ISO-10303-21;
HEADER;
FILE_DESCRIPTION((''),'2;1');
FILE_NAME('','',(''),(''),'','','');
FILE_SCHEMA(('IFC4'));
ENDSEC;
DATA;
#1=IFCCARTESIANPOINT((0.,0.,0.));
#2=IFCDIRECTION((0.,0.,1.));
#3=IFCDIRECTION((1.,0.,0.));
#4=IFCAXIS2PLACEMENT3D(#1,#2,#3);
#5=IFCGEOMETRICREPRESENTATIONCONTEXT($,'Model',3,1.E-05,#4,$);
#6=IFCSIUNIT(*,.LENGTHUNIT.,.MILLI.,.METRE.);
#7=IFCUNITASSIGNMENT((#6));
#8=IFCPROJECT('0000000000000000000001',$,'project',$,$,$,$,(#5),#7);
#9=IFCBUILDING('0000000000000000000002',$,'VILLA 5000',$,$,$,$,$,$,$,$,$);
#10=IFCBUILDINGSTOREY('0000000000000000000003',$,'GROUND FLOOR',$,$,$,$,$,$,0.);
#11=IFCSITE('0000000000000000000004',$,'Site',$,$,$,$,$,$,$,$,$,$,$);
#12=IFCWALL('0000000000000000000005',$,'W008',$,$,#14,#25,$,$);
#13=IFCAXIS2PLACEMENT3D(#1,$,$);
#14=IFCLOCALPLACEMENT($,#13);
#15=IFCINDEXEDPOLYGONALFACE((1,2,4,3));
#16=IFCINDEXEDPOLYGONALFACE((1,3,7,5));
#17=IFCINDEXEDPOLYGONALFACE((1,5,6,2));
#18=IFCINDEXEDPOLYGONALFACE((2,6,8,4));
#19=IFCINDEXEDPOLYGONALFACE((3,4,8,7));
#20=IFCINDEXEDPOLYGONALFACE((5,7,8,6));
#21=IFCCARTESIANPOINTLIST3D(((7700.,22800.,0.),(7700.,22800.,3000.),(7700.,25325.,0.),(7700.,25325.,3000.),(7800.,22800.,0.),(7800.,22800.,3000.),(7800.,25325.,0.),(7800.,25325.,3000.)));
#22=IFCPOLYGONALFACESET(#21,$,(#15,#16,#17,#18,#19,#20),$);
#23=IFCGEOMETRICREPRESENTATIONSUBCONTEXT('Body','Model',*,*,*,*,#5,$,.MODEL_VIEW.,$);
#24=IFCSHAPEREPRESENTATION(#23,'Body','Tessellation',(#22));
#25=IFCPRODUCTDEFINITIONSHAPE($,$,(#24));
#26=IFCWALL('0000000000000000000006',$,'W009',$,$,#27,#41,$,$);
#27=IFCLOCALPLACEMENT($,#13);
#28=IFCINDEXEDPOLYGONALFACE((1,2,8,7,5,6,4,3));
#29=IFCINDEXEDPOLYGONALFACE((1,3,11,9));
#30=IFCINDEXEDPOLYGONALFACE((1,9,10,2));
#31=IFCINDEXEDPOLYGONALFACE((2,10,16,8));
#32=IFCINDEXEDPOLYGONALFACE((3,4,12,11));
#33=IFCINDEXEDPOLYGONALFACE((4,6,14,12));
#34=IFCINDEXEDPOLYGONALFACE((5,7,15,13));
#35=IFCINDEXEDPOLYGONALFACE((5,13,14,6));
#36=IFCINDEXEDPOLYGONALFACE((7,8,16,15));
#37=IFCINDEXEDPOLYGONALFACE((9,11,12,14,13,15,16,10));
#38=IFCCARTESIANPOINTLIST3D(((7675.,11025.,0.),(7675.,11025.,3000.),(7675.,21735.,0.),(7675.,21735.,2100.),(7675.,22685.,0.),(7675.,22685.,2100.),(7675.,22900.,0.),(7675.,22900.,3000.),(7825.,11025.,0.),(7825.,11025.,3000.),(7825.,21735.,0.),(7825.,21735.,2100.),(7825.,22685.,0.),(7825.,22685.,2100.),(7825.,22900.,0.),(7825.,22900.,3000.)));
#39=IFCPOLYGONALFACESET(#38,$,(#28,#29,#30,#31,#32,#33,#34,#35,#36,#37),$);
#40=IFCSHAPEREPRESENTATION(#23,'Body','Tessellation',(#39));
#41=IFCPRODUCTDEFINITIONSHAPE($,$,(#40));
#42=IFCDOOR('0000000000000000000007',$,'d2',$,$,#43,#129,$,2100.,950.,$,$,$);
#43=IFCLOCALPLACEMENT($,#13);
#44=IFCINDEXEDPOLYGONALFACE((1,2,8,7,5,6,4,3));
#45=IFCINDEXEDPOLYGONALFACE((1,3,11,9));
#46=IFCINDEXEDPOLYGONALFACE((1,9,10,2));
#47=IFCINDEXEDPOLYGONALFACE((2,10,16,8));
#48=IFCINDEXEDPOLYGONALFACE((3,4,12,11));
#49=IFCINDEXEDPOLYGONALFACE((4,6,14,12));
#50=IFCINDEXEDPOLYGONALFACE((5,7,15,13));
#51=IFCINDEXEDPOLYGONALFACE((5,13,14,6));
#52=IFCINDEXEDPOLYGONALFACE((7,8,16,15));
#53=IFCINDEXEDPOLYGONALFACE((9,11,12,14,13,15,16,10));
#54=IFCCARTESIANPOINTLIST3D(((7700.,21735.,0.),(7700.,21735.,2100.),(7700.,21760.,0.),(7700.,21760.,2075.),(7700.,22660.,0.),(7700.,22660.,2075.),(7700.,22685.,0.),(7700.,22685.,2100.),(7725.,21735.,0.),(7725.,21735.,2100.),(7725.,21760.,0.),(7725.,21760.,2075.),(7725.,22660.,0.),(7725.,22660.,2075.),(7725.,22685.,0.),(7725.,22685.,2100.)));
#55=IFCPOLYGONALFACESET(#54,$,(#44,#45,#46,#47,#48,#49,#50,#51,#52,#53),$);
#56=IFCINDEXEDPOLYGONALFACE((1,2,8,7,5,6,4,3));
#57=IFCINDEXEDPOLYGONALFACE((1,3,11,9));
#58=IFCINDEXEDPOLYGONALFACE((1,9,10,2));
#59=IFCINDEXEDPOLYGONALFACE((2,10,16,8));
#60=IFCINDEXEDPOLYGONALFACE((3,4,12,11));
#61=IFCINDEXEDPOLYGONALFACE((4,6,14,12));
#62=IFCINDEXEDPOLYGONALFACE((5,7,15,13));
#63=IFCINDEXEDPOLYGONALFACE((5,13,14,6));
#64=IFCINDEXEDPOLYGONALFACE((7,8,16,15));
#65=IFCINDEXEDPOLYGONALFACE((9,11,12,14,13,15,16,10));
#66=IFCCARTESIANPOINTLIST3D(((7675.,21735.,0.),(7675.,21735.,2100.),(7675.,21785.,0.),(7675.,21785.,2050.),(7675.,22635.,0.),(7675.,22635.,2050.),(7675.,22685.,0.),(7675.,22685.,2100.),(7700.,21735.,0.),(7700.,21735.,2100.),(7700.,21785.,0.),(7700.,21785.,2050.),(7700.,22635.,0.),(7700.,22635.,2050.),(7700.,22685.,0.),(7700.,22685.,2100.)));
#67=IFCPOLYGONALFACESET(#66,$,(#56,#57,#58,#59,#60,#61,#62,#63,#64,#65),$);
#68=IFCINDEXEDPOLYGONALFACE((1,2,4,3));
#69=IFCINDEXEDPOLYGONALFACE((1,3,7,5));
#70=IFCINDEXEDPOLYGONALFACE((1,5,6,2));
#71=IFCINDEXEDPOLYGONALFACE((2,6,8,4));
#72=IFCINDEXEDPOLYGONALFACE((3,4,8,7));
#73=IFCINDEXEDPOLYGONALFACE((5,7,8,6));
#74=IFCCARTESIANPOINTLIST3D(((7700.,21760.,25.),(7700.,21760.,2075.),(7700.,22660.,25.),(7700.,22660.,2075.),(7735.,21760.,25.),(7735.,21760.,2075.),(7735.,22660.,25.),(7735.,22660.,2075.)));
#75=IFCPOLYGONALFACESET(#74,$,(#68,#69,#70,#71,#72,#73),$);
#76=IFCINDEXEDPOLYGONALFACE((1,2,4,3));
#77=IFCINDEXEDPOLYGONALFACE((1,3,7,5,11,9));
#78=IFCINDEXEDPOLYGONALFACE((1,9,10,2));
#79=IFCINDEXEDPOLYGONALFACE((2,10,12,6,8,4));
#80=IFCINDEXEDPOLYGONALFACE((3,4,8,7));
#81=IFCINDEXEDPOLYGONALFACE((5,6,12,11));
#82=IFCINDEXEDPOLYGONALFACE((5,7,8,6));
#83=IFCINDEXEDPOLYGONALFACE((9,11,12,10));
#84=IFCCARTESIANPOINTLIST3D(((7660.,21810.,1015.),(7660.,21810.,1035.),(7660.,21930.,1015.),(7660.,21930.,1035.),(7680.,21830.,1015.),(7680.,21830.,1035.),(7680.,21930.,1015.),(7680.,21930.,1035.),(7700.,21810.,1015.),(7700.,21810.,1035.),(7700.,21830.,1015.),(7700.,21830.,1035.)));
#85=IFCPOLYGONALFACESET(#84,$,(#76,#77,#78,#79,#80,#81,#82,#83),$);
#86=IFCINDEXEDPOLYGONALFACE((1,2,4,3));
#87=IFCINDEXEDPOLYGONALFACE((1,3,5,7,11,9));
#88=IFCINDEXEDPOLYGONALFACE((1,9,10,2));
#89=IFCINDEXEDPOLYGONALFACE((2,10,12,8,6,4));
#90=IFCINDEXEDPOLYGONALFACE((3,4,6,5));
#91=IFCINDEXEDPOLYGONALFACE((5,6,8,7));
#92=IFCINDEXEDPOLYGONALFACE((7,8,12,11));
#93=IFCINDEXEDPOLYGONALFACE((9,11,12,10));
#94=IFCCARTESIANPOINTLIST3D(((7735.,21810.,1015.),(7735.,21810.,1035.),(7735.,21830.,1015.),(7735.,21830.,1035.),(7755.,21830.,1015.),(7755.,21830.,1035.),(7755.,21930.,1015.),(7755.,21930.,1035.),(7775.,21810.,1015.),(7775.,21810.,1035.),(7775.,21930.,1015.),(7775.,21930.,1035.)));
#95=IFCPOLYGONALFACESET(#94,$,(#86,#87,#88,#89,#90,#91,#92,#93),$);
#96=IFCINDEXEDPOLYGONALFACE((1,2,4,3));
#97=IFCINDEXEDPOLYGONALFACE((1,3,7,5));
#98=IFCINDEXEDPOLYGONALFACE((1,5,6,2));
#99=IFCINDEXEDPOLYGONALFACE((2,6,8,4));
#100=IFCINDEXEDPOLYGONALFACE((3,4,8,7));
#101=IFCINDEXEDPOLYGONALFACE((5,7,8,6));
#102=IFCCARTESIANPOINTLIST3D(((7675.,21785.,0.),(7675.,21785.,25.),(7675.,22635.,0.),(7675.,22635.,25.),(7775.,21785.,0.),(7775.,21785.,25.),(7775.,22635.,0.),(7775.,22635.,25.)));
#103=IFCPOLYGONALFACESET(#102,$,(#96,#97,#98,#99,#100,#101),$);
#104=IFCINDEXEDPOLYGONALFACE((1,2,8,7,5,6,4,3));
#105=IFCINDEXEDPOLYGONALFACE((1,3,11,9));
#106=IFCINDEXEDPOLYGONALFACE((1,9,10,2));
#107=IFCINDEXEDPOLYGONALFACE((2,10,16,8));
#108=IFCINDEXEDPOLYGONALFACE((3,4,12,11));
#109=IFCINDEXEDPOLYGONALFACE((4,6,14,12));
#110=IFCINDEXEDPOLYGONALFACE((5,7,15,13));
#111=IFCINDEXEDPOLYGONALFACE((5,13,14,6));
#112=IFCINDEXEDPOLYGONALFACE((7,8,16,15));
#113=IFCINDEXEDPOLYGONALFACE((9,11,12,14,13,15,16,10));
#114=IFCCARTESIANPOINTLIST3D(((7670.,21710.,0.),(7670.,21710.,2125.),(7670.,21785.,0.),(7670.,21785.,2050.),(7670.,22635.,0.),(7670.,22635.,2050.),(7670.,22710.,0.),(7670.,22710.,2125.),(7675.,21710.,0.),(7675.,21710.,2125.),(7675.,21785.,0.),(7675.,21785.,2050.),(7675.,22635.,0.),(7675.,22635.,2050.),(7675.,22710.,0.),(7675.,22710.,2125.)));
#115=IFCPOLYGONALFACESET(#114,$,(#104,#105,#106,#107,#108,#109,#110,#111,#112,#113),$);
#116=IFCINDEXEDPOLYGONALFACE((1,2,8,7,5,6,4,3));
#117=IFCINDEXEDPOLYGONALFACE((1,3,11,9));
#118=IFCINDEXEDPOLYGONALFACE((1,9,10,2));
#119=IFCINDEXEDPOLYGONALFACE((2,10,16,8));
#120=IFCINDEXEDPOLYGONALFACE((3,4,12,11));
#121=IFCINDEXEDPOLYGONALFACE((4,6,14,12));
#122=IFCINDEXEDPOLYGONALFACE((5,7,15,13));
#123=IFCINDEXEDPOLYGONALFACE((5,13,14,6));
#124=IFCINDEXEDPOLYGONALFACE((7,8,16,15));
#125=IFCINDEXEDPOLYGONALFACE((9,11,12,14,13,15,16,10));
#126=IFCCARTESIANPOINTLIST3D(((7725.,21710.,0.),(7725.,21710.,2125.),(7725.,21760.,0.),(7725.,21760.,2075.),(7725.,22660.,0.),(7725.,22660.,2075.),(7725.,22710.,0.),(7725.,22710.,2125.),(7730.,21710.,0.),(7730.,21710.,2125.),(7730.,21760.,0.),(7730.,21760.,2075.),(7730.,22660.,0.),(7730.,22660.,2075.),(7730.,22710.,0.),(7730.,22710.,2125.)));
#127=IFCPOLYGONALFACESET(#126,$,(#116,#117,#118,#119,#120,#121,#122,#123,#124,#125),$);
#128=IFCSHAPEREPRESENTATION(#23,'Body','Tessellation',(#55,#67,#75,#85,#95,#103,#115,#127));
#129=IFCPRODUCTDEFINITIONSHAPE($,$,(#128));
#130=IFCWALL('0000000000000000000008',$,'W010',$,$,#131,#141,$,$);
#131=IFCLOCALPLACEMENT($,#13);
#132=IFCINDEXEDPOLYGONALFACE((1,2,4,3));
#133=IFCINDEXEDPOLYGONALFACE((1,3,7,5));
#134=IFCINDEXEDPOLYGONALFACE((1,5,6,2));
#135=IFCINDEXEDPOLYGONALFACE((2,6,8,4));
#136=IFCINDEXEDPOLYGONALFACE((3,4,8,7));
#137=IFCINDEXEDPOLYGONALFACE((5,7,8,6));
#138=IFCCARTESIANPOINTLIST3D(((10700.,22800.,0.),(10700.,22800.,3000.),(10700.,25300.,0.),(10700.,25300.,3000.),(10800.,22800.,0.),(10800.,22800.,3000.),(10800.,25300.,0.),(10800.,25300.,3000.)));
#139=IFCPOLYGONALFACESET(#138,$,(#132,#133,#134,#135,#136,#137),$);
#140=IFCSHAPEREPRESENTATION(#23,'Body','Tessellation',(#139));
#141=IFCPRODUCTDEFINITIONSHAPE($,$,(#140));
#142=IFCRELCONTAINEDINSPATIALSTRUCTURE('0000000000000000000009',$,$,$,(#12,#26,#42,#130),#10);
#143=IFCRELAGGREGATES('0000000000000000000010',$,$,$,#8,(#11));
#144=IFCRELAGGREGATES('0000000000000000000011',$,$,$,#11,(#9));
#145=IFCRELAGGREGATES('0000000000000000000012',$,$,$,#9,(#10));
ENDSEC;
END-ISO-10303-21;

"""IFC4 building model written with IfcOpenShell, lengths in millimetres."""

from ifc_helpers import new_model, si_unit, frame, origin_with_axes, place, context, subcontext, project, spatial, line, indexed_curve, outline, extrude, element, fill, save


model = new_model("IFC4")

# Units and contexts
model_context = context("Model", 3, precision=1e-05, world=origin_with_axes())
body_context = subcontext(model_context, "Body", "Model", "MODEL_VIEW")
ifc_project = project(units=[si_unit("LENGTHUNIT", "METRE", prefix="MILLI")], contexts=[model_context])

# Site, building, storey
site = spatial("IfcSite", under=ifc_project, Name="Site")
building = spatial("IfcBuilding", under=site, Name="VILLA 5000")
storey = spatial("IfcBuildingStorey", under=building, Name="GROUND FLOOR", Elevation=0.0)

# Wall
wall_1_placement = place(None, frame((7750.0, 25325.0, 0.0), z_axis=(0.0, 0.0, 1.0), x_axis=(0.0, -1.0, 0.0)))
element("IfcWall", 1, at=wall_1_placement, inside=storey, Name="W008", context=body_context, shape_type="SweptSolid", body=[
    extrude(outline(indexed_curve([(0.0, 0.0), (0.0, 100.0), (2525.0, 100.0), (2525.0, 0.0), (0.0, 0.0)], self_intersect=False)), frame((0.0, -50.0, 0.0), z_axis=(0.0, 0.0, 1.0), x_axis=(1.0, 0.0, 0.0)), (0.0, 0.0, 1.0), 3000.0),
])

# Wall, opening, door
wall_2_placement = place(None, frame((7750.0, 22900.0, 0.0), z_axis=(0.0, 0.0, 1.0), x_axis=(0.0, -1.0, 0.0)))
wall_2 = element("IfcWall", 2, at=wall_2_placement, inside=storey, Name="W009", context=body_context, shape_type="SweptSolid", body=[
    extrude(outline(indexed_curve([(0.0, 0.0), (0.0, 150.0), (11875.0, 150.0), (11875.0, 0.0), (0.0, 0.0)], self_intersect=False)), frame((0.0, -75.0, 0.0), z_axis=(0.0, 0.0, 1.0), x_axis=(1.0, 0.0, 0.0)), (0.0, 0.0, 1.0), 3000.0),
])
opening_1_placement = place(wall_2_placement, frame((215.0, 0.0, 0.0), z_axis=(0.0, 0.0, 1.0), x_axis=(1.0, 0.0, 0.0)))
opening_1 = element("IfcOpeningElement", 3, at=opening_1_placement, cuts=wall_2, context=body_context, shape_type="SweptSolid", body=[
    extrude(outline(indexed_curve([(0.0, 0.0), (0.0, 250.0), (950.0, 250.0), (950.0, 0.0), (0.0, 0.0)], self_intersect=False)), frame((0.0, -125.0, 0.0), z_axis=(0.0, 0.0, 1.0), x_axis=(1.0, 0.0, 0.0)), (0.0, 0.0, 1.0), 2100.0),
])
door_1_placement = place(None, frame((7675.0, 22685.0, 0.0), z_axis=(0.0, 0.0, 1.0), x_axis=(0.0, -1.0, 0.0)))
door_1 = element("IfcDoor", 4, at=door_1_placement, inside=storey, Name="d2", OverallHeight=2100.0, OverallWidth=950.0, context=body_context, shape_type="SweptSolid", body=[
    extrude(outline(indexed_curve([(0.0, 0.0), (0.0, 2100.0), (950.0, 2100.0), (950.0, 0.0), (925.0, 0.0), (925.0, 2075.0), (25.0, 2075.0), (25.0, 0.0)], segments=[line(1, 2, 3, 4, 5, 6, 7, 8, 1)])), frame((0.0, 25.0, 0.0), z_axis=(0.0, -1.0, 0.0), x_axis=(1.0, 0.0, 0.0)), (0.0, 0.0, -1.0), 25.0),
    extrude(outline(indexed_curve([(0.0, 0.0), (0.0, 2100.0), (950.0, 2100.0), (950.0, 0.0), (900.0, 0.0), (900.0, 2050.0), (50.0, 2050.0), (50.0, 0.0)], segments=[line(1, 2, 3, 4, 5, 6, 7, 8, 1)])), frame((0.0, 0.0, 0.0), z_axis=(0.0, -1.0, 0.0), x_axis=(1.0, 0.0, 0.0)), (0.0, 0.0, -1.0), 25.0),
    extrude(outline(indexed_curve([(0.0, 0.0), (900.0, 0.0), (900.0, 35.0), (0.0, 35.0)], segments=[line(1, 2, 3, 4, 1)])), frame((25.0, 25.0, 25.0), z_axis=(0.0, 0.0, 1.0), x_axis=(1.0, 0.0, 0.0)), (0.0, 0.0, 1.0), 2050.0),
    extrude(outline(indexed_curve([(0.0, 0.0), (0.0, -40.0), (-120.0, -40.0), (-120.0, -20.0), (-20.0, -20.0), (-20.0, 0.0)], segments=[line(1, 2, 3, 4, 5, 6, 1)])), frame((875.0, 25.0, 1015.0), z_axis=(0.0, 0.0, 1.0), x_axis=(1.0, 0.0, 0.0)), (0.0, 0.0, 1.0), 20.0),
    extrude(outline(indexed_curve([(0.0, 0.0), (0.0, 40.0), (-120.0, 40.0), (-120.0, 20.0), (-20.0, 20.0), (-20.0, 0.0)], segments=[line(1, 2, 3, 4, 5, 6, 1)])), frame((875.0, 60.0, 1015.0), z_axis=(0.0, 0.0, 1.0), x_axis=(1.0, 0.0, 0.0)), (0.0, 0.0, 1.0), 20.0),
    extrude(outline(indexed_curve([(0.0, 0.0), (850.0, 0.0), (850.0, 100.0), (0.0, 100.0)], segments=[line(1, 2, 3, 4, 1)])), frame((50.0, 0.0, 0.0), z_axis=(0.0, 0.0, 1.0), x_axis=(1.0, 0.0, 0.0)), (0.0, 0.0, 1.0), 25.0),
    extrude(outline(indexed_curve([(0.0, 0.0), (0.0, 2125.0), (1000.0, 2125.0), (1000.0, 0.0), (925.0, 0.0), (925.0, 2050.0), (75.0, 2050.0), (75.0, 0.0)], segments=[line(1, 2, 3, 4, 5, 6, 7, 8, 1)])), frame((-25.0, -5.0, 0.0), z_axis=(0.0, -1.0, 0.0), x_axis=(1.0, 0.0, 0.0)), (0.0, 0.0, -1.0), 5.0),
    extrude(outline(indexed_curve([(0.0, 0.0), (0.0, 2125.0), (1000.0, 2125.0), (1000.0, 0.0), (950.0, 0.0), (950.0, 2075.0), (50.0, 2075.0), (50.0, 0.0)], segments=[line(1, 2, 3, 4, 5, 6, 7, 8, 1)])), frame((-25.0, 50.0, 0.0), z_axis=(0.0, -1.0, 0.0), x_axis=(1.0, 0.0, 0.0)), (0.0, 0.0, -1.0), 5.0),
])
fill(opening_1, door_1)

# Wall
wall_3_placement = place(None, frame((10750.0, 25300.0, 0.0), z_axis=(0.0, 0.0, 1.0), x_axis=(0.0, -1.0, 0.0)))
element("IfcWall", 5, at=wall_3_placement, inside=storey, Name="W010", context=body_context, shape_type="SweptSolid", body=[
    extrude(outline(indexed_curve([(0.0, 0.0), (0.0, 100.0), (2500.0, 100.0), (2500.0, 0.0), (0.0, 0.0)], self_intersect=False)), frame((0.0, -50.0, 0.0), z_axis=(0.0, 0.0, 1.0), x_axis=(1.0, 0.0, 0.0)), (0.0, 0.0, 1.0), 3000.0),
])

save(model, "model.ifc")
